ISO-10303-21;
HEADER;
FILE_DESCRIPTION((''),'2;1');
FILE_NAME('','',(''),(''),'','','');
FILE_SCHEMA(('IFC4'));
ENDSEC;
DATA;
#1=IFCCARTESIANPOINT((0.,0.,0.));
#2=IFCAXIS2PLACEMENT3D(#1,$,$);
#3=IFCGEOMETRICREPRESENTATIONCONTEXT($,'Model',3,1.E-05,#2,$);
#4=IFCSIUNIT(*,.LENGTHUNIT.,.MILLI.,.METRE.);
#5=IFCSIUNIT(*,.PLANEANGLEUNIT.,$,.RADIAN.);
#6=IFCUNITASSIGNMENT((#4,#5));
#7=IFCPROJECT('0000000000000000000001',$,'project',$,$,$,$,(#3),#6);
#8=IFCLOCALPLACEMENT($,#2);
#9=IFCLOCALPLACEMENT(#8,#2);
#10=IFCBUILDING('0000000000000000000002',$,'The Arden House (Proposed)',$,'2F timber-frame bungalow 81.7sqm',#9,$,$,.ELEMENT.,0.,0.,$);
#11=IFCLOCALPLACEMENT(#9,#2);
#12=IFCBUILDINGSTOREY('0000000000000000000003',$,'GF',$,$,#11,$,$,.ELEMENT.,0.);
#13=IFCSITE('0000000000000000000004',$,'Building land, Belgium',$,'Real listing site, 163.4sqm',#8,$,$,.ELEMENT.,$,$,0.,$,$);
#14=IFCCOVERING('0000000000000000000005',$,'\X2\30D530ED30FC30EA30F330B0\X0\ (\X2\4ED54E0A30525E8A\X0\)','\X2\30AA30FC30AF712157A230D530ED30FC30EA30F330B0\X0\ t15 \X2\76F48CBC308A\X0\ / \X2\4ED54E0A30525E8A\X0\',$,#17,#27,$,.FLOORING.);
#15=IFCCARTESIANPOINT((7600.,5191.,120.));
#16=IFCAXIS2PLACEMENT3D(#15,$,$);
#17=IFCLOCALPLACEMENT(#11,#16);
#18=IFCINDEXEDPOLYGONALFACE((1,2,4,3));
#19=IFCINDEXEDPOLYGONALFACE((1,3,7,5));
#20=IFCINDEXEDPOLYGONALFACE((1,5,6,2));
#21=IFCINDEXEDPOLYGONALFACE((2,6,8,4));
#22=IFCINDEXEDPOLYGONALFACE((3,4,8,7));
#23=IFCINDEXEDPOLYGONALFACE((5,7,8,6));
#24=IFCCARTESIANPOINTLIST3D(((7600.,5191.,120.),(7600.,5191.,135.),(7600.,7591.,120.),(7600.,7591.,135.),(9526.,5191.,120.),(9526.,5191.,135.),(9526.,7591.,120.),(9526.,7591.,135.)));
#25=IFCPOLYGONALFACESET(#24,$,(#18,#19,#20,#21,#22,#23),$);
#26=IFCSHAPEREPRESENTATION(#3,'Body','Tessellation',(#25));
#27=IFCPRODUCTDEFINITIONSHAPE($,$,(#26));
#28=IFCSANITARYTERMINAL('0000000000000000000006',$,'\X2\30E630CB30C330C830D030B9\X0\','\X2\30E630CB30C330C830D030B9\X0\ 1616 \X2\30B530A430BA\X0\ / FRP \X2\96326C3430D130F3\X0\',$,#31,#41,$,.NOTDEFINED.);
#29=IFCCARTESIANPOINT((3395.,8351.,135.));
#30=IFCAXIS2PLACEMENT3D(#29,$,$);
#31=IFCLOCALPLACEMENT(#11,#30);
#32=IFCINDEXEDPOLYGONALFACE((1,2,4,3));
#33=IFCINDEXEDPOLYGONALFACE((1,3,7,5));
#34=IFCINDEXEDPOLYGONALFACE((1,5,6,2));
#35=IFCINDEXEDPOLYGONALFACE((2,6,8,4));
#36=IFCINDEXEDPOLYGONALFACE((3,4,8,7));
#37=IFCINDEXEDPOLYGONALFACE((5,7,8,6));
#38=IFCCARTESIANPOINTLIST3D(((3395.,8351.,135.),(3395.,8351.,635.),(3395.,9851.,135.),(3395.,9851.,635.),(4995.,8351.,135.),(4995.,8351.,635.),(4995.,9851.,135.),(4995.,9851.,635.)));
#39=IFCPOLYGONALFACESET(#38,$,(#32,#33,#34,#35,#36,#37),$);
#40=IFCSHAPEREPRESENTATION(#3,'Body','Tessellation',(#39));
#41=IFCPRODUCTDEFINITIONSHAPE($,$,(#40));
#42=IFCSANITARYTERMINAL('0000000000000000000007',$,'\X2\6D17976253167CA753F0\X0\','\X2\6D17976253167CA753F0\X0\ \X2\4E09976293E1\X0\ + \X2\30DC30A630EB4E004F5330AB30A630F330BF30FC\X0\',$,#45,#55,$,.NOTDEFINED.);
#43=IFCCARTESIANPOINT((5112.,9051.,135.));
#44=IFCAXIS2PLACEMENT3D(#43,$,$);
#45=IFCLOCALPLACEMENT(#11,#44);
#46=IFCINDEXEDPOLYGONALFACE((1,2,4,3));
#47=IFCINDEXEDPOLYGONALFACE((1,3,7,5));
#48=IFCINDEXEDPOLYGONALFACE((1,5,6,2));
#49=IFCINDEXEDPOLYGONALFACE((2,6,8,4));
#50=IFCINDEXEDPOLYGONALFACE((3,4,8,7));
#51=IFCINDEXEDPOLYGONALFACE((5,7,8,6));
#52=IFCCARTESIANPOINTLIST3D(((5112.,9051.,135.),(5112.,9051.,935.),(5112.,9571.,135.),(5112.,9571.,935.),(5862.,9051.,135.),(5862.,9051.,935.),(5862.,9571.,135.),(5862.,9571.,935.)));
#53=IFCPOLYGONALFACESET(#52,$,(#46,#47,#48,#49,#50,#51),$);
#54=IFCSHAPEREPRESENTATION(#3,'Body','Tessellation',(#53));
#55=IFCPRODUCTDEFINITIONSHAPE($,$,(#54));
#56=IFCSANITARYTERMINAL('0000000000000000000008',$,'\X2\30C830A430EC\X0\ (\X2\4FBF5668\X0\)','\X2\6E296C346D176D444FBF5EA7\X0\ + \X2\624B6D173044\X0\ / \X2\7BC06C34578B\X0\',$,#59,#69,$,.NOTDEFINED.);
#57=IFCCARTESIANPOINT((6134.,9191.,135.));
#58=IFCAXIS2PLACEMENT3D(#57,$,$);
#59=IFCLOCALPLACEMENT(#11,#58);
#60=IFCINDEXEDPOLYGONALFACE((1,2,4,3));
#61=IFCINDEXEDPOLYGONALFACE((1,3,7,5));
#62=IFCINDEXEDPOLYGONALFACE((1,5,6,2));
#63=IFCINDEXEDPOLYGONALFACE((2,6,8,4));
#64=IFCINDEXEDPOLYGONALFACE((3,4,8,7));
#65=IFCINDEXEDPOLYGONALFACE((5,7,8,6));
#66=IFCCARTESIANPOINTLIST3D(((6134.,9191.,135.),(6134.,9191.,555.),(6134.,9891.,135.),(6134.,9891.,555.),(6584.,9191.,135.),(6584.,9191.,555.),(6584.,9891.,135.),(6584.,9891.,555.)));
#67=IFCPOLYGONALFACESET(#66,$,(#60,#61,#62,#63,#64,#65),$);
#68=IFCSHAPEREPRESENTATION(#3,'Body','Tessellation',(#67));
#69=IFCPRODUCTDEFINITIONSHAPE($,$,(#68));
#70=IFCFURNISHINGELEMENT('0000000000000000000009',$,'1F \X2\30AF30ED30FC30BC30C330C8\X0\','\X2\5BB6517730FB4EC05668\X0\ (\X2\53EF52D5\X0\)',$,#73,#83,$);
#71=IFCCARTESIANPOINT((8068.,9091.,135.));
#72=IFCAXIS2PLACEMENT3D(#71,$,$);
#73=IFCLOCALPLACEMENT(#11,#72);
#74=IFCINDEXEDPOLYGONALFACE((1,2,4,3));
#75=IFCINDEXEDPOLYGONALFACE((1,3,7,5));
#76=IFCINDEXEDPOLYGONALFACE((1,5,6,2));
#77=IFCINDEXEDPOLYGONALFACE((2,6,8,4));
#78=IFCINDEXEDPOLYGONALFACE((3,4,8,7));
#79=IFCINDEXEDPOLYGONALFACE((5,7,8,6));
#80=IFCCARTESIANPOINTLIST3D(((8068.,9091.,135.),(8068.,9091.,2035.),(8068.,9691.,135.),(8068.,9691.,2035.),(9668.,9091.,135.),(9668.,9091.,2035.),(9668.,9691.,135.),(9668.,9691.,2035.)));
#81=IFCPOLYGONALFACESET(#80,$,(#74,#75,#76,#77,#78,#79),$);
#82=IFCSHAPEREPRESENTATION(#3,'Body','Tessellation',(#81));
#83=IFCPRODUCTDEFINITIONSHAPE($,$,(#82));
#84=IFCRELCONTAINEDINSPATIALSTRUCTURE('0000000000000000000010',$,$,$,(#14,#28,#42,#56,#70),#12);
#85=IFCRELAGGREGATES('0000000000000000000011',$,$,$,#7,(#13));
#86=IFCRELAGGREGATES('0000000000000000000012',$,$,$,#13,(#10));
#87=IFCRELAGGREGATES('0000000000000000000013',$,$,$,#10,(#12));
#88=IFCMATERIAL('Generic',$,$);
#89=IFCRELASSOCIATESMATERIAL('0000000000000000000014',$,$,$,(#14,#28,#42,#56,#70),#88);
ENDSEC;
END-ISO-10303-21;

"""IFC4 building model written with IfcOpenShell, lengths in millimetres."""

from ifc_helpers import new_model, si_unit, frame, frame_2d, origin, place, context, project, spatial, rectangle, extrude, material, element, save


model = new_model("IFC4")

# Units and contexts
model_context = context("Model", 3, precision=1e-05, world=origin())
ifc_project = project(units=[si_unit("LENGTHUNIT", "METRE", prefix="MILLI"), si_unit("PLANEANGLEUNIT", "RADIAN")], contexts=[model_context])

# Site, building, storey
site_placement = place(None, origin())
site = spatial("IfcSite", under=ifc_project, at=site_placement, Name="Building land, Belgium", ObjectType="Real listing site, 163.4sqm", CompositionType="ELEMENT", RefElevation=0.0)
building_placement = place(site_placement, origin())
building = spatial("IfcBuilding", under=site, at=building_placement, Name="The Arden House (Proposed)", ObjectType="2F timber-frame bungalow 81.7sqm", CompositionType="ELEMENT", ElevationOfRefHeight=0.0, ElevationOfTerrain=0.0)
storey_placement = place(building_placement, origin())
storey = spatial("IfcBuildingStorey", under=building, at=storey_placement, Name="GF", CompositionType="ELEMENT", Elevation=0.0)

# Covering
ifc_material_1 = material(Name="Generic")
covering_1_placement = place(storey_placement, frame((7600.0, 5191.0, 120.0)))
element("IfcCovering", 1, at=covering_1_placement, inside=storey, material=ifc_material_1, Name="フローリング (仕上げ床)", Description="オーク無垢フローリング t15 直貼り / 仕上げ床", PredefinedType="FLOORING", context=model_context, shape_type="SweptSolid", body=[
    extrude(rectangle(XDim=1926.0, YDim=2400.0, at=frame_2d((963.0, 1200.0))), frame((7600.0, 5191.0, 120.0)), (0.0, 0.0, 1.0), 15.0),
])

# Sanitary terminals
sanitary_terminal_1_placement = place(storey_placement, frame((3395.0, 8351.0, 135.0)))
element("IfcSanitaryTerminal", 2, at=sanitary_terminal_1_placement, inside=storey, material=ifc_material_1, Name="ユニットバス", Description="ユニットバス 1616 サイズ / FRP 防水パン", PredefinedType="NOTDEFINED", context=model_context, shape_type="SweptSolid", body=[
    extrude(rectangle(XDim=1600.0, YDim=1500.0, at=frame_2d((800.0, 750.0))), frame((3395.0, 8351.0, 135.0)), (0.0, 0.0, 1.0), 500.0),
])
sanitary_terminal_2_placement = place(storey_placement, frame((5112.0, 9051.0, 135.0)))
element("IfcSanitaryTerminal", 3, at=sanitary_terminal_2_placement, inside=storey, material=ifc_material_1, Name="洗面化粧台", Description="洗面化粧台 三面鏡 + ボウル一体カウンター", PredefinedType="NOTDEFINED", context=model_context, shape_type="SweptSolid", body=[
    extrude(rectangle(XDim=750.0, YDim=520.0, at=frame_2d((375.0, 260.0))), frame((5112.0, 9051.0, 135.0)), (0.0, 0.0, 1.0), 800.0),
])
sanitary_terminal_3_placement = place(storey_placement, frame((6134.0, 9191.0, 135.0)))
element("IfcSanitaryTerminal", 4, at=sanitary_terminal_3_placement, inside=storey, material=ifc_material_1, Name="トイレ (便器)", Description="温水洗浄便座 + 手洗い / 節水型", PredefinedType="NOTDEFINED", context=model_context, shape_type="SweptSolid", body=[
    extrude(rectangle(XDim=450.0, YDim=700.0, at=frame_2d((225.0, 350.0))), frame((6134.0, 9191.0, 135.0)), (0.0, 0.0, 1.0), 420.0),
])

# Furnishing element
furnishing_placement = place(storey_placement, frame((8068.0, 9091.0, 135.0)))
element("IfcFurnishingElement", 5, at=furnishing_placement, inside=storey, material=ifc_material_1, Name="1F クローゼット", Description="家具・什器 (可動)", context=model_context, shape_type="SweptSolid", body=[
    extrude(rectangle(XDim=1600.0, YDim=600.0, at=frame_2d((800.0, 300.0))), frame((8068.0, 9091.0, 135.0)), (0.0, 0.0, 1.0), 1900.0),
])

save(model, "model.ifc")
